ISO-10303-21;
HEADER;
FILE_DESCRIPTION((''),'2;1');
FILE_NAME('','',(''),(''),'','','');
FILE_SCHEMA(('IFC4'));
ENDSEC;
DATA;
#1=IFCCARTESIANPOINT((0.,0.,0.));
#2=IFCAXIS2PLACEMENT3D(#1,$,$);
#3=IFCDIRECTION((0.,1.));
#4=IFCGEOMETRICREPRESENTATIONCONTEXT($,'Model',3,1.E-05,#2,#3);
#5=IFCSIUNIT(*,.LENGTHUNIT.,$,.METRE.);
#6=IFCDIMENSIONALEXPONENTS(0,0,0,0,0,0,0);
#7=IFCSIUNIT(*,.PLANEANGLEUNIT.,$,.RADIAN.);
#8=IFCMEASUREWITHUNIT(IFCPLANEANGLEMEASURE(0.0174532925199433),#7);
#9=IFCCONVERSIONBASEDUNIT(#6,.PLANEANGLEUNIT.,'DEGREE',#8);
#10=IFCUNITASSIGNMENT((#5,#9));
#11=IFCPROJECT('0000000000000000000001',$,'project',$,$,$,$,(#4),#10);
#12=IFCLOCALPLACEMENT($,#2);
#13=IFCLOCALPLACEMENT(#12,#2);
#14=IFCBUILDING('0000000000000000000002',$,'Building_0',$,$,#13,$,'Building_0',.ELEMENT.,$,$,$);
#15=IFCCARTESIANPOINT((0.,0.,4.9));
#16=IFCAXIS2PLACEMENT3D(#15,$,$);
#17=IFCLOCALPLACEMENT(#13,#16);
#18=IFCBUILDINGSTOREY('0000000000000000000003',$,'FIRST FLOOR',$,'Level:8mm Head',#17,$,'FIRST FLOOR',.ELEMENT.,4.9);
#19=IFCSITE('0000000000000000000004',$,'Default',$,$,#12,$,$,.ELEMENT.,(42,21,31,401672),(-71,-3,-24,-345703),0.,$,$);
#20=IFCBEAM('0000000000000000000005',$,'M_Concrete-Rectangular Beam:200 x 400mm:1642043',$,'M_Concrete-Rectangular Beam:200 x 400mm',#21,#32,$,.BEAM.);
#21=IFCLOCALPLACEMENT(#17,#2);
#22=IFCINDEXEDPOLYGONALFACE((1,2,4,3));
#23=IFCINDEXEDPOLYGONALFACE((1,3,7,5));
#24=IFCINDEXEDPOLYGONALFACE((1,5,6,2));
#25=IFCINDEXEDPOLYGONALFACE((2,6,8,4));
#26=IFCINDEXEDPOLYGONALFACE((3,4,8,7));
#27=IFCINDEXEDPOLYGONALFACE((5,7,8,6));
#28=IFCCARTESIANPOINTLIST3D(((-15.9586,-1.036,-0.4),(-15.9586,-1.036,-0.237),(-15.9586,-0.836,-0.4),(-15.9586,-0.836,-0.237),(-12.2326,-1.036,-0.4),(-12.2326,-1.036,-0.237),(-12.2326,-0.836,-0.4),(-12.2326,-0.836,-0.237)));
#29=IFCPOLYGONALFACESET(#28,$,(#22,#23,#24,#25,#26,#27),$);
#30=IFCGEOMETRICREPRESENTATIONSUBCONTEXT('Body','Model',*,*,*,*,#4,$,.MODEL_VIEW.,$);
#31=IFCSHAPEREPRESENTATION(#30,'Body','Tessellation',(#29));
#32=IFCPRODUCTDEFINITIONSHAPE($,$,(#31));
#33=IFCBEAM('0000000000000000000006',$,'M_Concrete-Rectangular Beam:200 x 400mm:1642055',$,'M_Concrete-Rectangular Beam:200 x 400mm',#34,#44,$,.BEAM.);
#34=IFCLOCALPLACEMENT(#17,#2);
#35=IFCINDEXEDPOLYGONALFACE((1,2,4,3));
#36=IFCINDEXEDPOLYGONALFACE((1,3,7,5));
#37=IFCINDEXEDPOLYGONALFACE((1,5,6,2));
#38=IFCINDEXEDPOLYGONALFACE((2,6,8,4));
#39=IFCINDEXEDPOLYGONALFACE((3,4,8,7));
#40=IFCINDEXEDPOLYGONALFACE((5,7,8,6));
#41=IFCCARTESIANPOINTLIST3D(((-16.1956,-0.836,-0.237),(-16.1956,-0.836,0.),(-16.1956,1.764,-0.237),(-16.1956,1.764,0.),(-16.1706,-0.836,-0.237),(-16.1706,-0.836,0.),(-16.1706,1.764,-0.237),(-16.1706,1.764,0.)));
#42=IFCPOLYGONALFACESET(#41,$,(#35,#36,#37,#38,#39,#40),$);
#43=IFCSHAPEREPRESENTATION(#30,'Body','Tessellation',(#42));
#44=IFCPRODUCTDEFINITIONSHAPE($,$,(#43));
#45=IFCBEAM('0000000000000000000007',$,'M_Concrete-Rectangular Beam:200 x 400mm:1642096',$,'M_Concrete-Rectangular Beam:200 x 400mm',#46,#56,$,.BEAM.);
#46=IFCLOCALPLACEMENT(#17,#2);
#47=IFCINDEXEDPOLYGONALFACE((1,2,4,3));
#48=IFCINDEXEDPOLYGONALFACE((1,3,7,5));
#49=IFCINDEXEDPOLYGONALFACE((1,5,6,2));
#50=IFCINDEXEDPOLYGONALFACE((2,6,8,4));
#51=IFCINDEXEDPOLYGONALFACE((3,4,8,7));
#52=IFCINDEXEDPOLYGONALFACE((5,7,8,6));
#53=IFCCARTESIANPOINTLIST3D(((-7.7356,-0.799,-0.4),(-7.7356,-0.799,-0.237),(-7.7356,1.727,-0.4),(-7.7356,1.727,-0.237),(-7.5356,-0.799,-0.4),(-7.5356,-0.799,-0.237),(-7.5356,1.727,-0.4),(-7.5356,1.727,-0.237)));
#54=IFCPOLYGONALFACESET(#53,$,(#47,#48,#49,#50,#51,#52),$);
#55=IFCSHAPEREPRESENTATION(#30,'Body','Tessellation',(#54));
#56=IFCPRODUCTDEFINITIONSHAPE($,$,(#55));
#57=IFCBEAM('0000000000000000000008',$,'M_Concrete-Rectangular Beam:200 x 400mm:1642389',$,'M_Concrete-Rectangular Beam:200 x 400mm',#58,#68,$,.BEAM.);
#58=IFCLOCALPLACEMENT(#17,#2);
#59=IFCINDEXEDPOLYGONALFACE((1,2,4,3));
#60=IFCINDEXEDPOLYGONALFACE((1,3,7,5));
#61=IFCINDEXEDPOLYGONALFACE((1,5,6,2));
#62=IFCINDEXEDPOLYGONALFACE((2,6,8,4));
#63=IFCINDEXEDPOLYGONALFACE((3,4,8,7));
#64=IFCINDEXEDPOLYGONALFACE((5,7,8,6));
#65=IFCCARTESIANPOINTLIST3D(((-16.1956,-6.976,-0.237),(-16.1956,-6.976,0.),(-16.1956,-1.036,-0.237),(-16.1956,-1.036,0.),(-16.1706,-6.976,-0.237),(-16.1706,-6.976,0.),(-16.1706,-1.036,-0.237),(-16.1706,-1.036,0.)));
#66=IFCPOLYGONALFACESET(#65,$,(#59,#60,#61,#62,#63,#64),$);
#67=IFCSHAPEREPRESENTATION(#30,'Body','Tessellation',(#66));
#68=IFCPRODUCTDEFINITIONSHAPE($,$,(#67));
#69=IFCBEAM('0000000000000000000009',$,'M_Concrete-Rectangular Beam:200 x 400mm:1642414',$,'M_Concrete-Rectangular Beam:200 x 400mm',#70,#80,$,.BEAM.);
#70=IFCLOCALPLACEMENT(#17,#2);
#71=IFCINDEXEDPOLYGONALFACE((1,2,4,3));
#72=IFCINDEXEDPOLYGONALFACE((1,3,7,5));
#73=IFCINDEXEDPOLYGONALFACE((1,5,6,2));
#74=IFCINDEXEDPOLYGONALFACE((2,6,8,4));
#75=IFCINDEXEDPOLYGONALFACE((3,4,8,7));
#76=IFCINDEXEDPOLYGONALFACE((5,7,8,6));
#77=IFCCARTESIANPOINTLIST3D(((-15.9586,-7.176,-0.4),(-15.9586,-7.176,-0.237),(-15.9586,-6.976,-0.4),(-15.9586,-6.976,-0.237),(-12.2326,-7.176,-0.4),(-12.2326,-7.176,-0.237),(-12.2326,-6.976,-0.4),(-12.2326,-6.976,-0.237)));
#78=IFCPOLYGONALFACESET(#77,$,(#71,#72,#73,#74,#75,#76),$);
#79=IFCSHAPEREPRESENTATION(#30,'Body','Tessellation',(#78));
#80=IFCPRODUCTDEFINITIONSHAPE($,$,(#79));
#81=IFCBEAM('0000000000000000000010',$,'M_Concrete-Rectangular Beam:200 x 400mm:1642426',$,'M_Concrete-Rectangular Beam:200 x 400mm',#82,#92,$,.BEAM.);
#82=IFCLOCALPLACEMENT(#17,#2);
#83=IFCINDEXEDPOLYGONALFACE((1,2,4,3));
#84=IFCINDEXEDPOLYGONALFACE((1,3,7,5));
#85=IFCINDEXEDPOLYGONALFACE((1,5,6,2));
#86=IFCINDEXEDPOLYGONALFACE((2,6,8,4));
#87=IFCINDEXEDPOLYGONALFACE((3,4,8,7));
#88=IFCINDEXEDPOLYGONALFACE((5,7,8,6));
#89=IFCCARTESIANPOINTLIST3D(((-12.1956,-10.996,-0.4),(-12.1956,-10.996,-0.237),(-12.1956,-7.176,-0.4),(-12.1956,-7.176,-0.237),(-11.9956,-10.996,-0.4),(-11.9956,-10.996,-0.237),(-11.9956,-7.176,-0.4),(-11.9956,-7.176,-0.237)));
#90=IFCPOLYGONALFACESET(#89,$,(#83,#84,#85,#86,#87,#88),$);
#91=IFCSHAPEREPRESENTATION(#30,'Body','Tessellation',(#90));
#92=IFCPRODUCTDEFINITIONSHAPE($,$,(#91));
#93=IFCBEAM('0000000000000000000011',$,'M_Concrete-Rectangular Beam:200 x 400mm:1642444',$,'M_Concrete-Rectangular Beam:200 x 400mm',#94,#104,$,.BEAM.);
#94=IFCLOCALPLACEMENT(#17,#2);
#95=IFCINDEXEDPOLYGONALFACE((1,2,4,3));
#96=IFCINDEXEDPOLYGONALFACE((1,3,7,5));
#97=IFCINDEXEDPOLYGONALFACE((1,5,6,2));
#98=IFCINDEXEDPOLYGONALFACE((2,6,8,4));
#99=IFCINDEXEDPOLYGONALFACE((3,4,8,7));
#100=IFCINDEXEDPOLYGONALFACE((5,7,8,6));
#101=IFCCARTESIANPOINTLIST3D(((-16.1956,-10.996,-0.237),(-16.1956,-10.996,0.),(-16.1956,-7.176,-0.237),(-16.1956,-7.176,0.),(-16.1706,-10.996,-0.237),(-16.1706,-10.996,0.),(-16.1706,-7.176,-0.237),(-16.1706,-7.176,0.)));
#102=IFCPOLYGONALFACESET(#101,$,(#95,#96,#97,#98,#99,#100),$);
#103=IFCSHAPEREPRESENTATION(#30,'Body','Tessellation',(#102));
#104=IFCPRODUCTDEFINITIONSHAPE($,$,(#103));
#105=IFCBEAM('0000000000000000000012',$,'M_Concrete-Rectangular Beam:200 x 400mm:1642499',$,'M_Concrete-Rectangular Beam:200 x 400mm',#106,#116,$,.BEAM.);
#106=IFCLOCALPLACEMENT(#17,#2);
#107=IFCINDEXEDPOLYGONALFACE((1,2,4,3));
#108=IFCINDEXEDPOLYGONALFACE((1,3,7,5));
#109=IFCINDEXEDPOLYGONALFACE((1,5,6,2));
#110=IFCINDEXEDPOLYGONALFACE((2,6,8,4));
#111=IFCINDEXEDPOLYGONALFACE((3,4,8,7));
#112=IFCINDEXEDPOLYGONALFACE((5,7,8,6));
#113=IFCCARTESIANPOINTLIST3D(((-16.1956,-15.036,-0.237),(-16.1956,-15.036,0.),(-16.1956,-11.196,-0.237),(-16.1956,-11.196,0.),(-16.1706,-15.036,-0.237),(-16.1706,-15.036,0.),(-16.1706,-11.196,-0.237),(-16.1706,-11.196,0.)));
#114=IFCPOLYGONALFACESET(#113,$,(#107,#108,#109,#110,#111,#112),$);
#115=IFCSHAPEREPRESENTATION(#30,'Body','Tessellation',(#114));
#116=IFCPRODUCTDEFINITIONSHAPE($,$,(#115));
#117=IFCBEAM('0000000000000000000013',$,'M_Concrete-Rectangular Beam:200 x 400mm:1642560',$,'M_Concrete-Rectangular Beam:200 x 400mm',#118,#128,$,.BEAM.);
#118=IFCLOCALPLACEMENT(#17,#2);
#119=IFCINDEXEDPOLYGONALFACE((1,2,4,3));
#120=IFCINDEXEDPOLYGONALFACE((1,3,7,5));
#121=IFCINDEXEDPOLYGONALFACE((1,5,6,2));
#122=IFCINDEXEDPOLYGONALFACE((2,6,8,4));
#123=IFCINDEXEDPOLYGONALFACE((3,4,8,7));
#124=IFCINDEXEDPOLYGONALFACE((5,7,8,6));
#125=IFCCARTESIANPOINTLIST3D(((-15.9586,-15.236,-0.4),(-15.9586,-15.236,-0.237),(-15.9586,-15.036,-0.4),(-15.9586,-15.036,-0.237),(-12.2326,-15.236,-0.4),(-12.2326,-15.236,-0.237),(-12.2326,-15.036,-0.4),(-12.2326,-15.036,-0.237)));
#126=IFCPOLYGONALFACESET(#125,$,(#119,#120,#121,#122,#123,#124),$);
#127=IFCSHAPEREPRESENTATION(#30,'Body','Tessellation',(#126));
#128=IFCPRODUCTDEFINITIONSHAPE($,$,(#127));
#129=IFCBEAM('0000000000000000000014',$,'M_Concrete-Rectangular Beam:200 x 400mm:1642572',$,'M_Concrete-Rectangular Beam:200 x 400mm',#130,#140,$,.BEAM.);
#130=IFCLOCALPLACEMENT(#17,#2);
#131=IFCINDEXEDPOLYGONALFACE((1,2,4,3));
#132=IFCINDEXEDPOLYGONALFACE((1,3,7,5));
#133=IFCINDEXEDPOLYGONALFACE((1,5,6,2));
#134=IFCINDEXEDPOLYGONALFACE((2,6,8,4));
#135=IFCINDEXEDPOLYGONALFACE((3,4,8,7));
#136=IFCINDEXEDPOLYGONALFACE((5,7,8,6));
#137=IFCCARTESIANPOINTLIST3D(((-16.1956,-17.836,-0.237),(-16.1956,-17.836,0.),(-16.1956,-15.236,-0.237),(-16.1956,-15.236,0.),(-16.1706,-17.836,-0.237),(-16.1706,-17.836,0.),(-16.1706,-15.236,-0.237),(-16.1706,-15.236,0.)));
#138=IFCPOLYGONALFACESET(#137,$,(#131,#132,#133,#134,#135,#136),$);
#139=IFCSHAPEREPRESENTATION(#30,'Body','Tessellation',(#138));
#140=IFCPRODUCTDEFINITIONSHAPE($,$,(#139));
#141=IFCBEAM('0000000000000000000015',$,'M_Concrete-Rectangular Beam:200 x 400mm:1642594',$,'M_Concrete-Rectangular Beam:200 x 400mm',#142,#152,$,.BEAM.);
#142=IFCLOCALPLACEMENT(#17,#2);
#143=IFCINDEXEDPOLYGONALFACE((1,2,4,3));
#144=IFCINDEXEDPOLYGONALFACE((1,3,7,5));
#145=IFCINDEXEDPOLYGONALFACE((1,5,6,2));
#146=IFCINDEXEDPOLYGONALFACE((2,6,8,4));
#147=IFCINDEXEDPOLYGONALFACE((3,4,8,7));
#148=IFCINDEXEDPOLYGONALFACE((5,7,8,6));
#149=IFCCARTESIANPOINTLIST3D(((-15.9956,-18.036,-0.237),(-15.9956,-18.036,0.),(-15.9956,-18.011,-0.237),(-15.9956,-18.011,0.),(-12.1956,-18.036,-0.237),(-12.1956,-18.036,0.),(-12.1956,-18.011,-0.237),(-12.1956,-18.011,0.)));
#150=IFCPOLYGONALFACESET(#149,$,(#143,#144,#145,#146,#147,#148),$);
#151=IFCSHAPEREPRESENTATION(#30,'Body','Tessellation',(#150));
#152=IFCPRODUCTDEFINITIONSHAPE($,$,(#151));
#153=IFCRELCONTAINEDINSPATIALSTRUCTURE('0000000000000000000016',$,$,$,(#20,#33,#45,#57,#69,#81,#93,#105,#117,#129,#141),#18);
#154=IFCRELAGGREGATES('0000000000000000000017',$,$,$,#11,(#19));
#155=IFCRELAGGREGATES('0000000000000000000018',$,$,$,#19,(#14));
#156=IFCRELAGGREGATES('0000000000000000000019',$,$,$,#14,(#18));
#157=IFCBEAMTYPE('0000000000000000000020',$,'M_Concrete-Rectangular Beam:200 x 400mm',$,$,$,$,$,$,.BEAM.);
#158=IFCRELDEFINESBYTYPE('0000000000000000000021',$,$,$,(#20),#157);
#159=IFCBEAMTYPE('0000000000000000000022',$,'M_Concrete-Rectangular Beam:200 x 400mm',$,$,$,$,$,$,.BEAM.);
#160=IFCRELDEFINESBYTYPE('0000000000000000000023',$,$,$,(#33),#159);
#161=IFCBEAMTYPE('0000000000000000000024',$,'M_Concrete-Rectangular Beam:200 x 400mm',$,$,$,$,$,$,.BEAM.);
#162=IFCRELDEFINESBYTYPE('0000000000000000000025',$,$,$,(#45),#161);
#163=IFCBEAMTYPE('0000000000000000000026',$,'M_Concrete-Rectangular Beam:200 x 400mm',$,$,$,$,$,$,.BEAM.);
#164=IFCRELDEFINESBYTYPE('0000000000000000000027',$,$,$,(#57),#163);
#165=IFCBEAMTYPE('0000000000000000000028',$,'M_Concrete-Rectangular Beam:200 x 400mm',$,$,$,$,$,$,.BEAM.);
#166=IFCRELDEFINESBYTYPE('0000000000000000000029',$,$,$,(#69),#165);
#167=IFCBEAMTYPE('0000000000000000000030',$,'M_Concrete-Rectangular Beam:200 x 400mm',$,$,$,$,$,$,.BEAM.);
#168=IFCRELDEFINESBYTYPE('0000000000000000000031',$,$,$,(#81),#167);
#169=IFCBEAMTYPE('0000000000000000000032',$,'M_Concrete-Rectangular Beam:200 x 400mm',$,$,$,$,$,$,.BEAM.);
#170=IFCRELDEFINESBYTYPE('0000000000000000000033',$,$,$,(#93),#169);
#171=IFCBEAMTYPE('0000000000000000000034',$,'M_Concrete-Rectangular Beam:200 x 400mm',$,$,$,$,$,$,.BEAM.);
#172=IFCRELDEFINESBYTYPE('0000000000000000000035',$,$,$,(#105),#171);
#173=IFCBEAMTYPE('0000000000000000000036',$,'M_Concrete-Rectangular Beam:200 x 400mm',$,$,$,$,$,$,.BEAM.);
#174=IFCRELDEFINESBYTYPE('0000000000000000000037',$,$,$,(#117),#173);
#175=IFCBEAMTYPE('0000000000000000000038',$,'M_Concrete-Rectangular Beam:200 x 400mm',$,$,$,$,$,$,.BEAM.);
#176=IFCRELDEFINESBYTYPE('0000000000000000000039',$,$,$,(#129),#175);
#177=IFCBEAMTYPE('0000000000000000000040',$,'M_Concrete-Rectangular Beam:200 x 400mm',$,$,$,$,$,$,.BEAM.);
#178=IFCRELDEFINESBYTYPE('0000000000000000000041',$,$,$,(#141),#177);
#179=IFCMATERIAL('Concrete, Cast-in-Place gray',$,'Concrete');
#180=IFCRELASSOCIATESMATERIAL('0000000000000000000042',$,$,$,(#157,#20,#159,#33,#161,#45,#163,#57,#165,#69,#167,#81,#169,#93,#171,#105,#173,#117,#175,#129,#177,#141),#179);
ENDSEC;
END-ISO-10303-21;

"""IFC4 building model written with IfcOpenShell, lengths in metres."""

from ifc_helpers import new_model, entity, si_unit, converted_unit, direction, frame, origin, place, context, subcontext, project, spatial, indexed_curve, outline, extrude, source, transform, mapped, material, type_object, type_shapes, element, save


model = new_model("IFC4")

# Units and contexts
model_context = context("Model", 3, precision=1e-05, world=origin(), true_north=direction((0.0, 1.0)))
body_context = subcontext(model_context, "Body", "Model", "MODEL_VIEW")
ifc_project = project(units=[si_unit("LENGTHUNIT", "METRE"), converted_unit("PLANEANGLEUNIT", "DEGREE", entity("IfcPlaneAngleMeasure", 0.0174532925199433), si_unit("PLANEANGLEUNIT", "RADIAN"), dimensions=[0, 0, 0, 0, 0, 0, 0])], contexts=[model_context])

# Site, building, storey
site_placement = place(None, origin())
site = spatial("IfcSite", under=ifc_project, at=site_placement, Name="Default", CompositionType="ELEMENT", RefLatitude=(42, 21, 31, 401672), RefLongitude=(-71, -3, -24, -345703), RefElevation=0.0)
building_placement = place(site_placement, origin())
building = spatial("IfcBuilding", under=site, at=building_placement, Name="Building_0", LongName="Building_0", CompositionType="ELEMENT")
storey_placement = place(building_placement, frame((0.0, 0.0, 4.9)))
storey = spatial("IfcBuildingStorey", under=building, at=storey_placement, Name="FIRST FLOOR", ObjectType="Level:8mm Head", LongName="FIRST FLOOR", CompositionType="ELEMENT", Elevation=4.9)

# Beams
ifc_material = material(Name="Concrete, Cast-in-Place gray", Category="Concrete")
beam_type_1 = type_object("IfcBeamType", Name="M_Concrete-Rectangular Beam:200 x 400mm", PredefinedType="BEAM", material=ifc_material)
shared_shape_1 = source(origin(), body_context, "Body", "SweptSolid", [
    extrude(outline(indexed_curve([(-0.0815, -0.1), (0.0815, -0.1), (0.0815, 0.1), (-0.0815, 0.1), (-0.0815, -0.1)], self_intersect=False)), frame((-12.2326, -0.936, 4.5815), z_axis=(-1.0, 0.0, 0.0), x_axis=(0.0, 0.0, -1.0)), (0.0, 0.0, 1.0), 3.726),
])
type_shapes(beam_type_1, [shared_shape_1])
beam_1_placement = place(storey_placement, frame((0.0, 0.0, -4.9)))
element("IfcBeam", 1, at=beam_1_placement, inside=storey, type_object=beam_type_1, material=ifc_material, Name="M_Concrete-Rectangular Beam:200 x 400mm:1642043", ObjectType="M_Concrete-Rectangular Beam:200 x 400mm", PredefinedType="BEAM", context=body_context, shape_type="MappedRepresentation", body=[
    mapped(shared_shape_1, transform((0.0, 0.0, 0.0), scale=1.0)),
])
beam_type_2 = type_object("IfcBeamType", Name="M_Concrete-Rectangular Beam:200 x 400mm", PredefinedType="BEAM", material=ifc_material)
shared_shape_2 = source(origin(), body_context, "Body", "SweptSolid", [
    extrude(outline(indexed_curve([(-0.0125, -0.1185), (0.0125, -0.1185), (0.0125, 0.1185), (-0.0125, 0.1185), (-0.0125, -0.1185)], self_intersect=False)), frame((-16.1831, -0.836, 4.7815), z_axis=(0.0, 1.0, 0.0), x_axis=(-1.0, 0.0, 0.0)), (0.0, 0.0, 1.0), 2.6),
])
type_shapes(beam_type_2, [shared_shape_2])
beam_2_placement = place(storey_placement, frame((0.0, 0.0, -4.9)))
element("IfcBeam", 2, at=beam_2_placement, inside=storey, type_object=beam_type_2, material=ifc_material, Name="M_Concrete-Rectangular Beam:200 x 400mm:1642055", ObjectType="M_Concrete-Rectangular Beam:200 x 400mm", PredefinedType="BEAM", context=body_context, shape_type="MappedRepresentation", body=[
    mapped(shared_shape_2, transform((0.0, 0.0, 0.0), scale=1.0)),
])
beam_type_3 = type_object("IfcBeamType", Name="M_Concrete-Rectangular Beam:200 x 400mm", PredefinedType="BEAM", material=ifc_material)
shared_shape_3 = source(origin(), body_context, "Body", "SweptSolid", [
    extrude(outline(indexed_curve([(-0.1, -0.0815), (0.1, -0.0815), (0.1, 0.0815), (-0.1, 0.0815), (-0.1, -0.0815)], self_intersect=False)), frame((-7.6356, 1.727, 4.5815), z_axis=(0.0, -1.0, 0.0), x_axis=(-1.0, 0.0, 0.0)), (0.0, 0.0, 1.0), 2.526),
])
type_shapes(beam_type_3, [shared_shape_3])
beam_3_placement = place(storey_placement, frame((0.0, 0.0, -4.9)))
element("IfcBeam", 3, at=beam_3_placement, inside=storey, type_object=beam_type_3, material=ifc_material, Name="M_Concrete-Rectangular Beam:200 x 400mm:1642096", ObjectType="M_Concrete-Rectangular Beam:200 x 400mm", PredefinedType="BEAM", context=body_context, shape_type="MappedRepresentation", body=[
    mapped(shared_shape_3, transform((0.0, 0.0, 0.0), scale=1.0)),
])
beam_type_4 = type_object("IfcBeamType", Name="M_Concrete-Rectangular Beam:200 x 400mm", PredefinedType="BEAM", material=ifc_material)
shared_shape_4 = source(origin(), body_context, "Body", "SweptSolid", [
    extrude(outline(indexed_curve([(-0.0125, -0.1185), (0.0125, -0.1185), (0.0125, 0.1185), (-0.0125, 0.1185), (-0.0125, -0.1185)], self_intersect=False)), frame((-16.1831, -1.036, 4.7815), z_axis=(0.0, -1.0, 0.0), x_axis=(-1.0, 0.0, 0.0)), (0.0, 0.0, 1.0), 5.94),
])
type_shapes(beam_type_4, [shared_shape_4])
beam_4_placement = place(storey_placement, frame((0.0, 0.0, -4.9)))
element("IfcBeam", 4, at=beam_4_placement, inside=storey, type_object=beam_type_4, material=ifc_material, Name="M_Concrete-Rectangular Beam:200 x 400mm:1642389", ObjectType="M_Concrete-Rectangular Beam:200 x 400mm", PredefinedType="BEAM", context=body_context, shape_type="MappedRepresentation", body=[
    mapped(shared_shape_4, transform((0.0, 0.0, 0.0), scale=1.0)),
])
beam_type_5 = type_object("IfcBeamType", Name="M_Concrete-Rectangular Beam:200 x 400mm", PredefinedType="BEAM", material=ifc_material)
shared_shape_5 = source(origin(), body_context, "Body", "SweptSolid", [
    extrude(outline(indexed_curve([(-0.0815, -0.1), (0.0815, -0.1), (0.0815, 0.1), (-0.0815, 0.1), (-0.0815, -0.1)], self_intersect=False)), frame((-15.9586, -7.076, 4.5815), z_axis=(1.0, 0.0, 0.0), x_axis=(0.0, 0.0, -1.0)), (0.0, 0.0, 1.0), 3.726),
])
type_shapes(beam_type_5, [shared_shape_5])
beam_5_placement = place(storey_placement, frame((0.0, 0.0, -4.9)))
element("IfcBeam", 5, at=beam_5_placement, inside=storey, type_object=beam_type_5, material=ifc_material, Name="M_Concrete-Rectangular Beam:200 x 400mm:1642414", ObjectType="M_Concrete-Rectangular Beam:200 x 400mm", PredefinedType="BEAM", context=body_context, shape_type="MappedRepresentation", body=[
    mapped(shared_shape_5, transform((0.0, 0.0, 0.0), scale=1.0)),
])
beam_type_6 = type_object("IfcBeamType", Name="M_Concrete-Rectangular Beam:200 x 400mm", PredefinedType="BEAM", material=ifc_material)
shared_shape_6 = source(origin(), body_context, "Body", "SweptSolid", [
    extrude(outline(indexed_curve([(-0.1, -0.0815), (0.1, -0.0815), (0.1, 0.0815), (-0.1, 0.0815), (-0.1, -0.0815)], self_intersect=False)), frame((-12.0956, -7.176, 4.5815), z_axis=(0.0, -1.0, 0.0), x_axis=(-1.0, 0.0, 0.0)), (0.0, 0.0, 1.0), 3.82),
])
type_shapes(beam_type_6, [shared_shape_6])
beam_6_placement = place(storey_placement, frame((0.0, 0.0, -4.9)))
element("IfcBeam", 6, at=beam_6_placement, inside=storey, type_object=beam_type_6, material=ifc_material, Name="M_Concrete-Rectangular Beam:200 x 400mm:1642426", ObjectType="M_Concrete-Rectangular Beam:200 x 400mm", PredefinedType="BEAM", context=body_context, shape_type="MappedRepresentation", body=[
    mapped(shared_shape_6, transform((0.0, 0.0, 0.0), scale=1.0)),
])
beam_type_7 = type_object("IfcBeamType", Name="M_Concrete-Rectangular Beam:200 x 400mm", PredefinedType="BEAM", material=ifc_material)
shared_shape_7 = source(origin(), body_context, "Body", "SweptSolid", [
    extrude(outline(indexed_curve([(-0.0125, -0.1185), (0.0125, -0.1185), (0.0125, 0.1185), (-0.0125, 0.1185), (-0.0125, -0.1185)], self_intersect=False)), frame((-16.1831, -7.176, 4.7815), z_axis=(0.0, -1.0, 0.0), x_axis=(-1.0, 0.0, 0.0)), (0.0, 0.0, 1.0), 3.82),
])
type_shapes(beam_type_7, [shared_shape_7])
beam_7_placement = place(storey_placement, frame((0.0, 0.0, -4.9)))
element("IfcBeam", 7, at=beam_7_placement, inside=storey, type_object=beam_type_7, material=ifc_material, Name="M_Concrete-Rectangular Beam:200 x 400mm:1642444", ObjectType="M_Concrete-Rectangular Beam:200 x 400mm", PredefinedType="BEAM", context=body_context, shape_type="MappedRepresentation", body=[
    mapped(shared_shape_7, transform((0.0, 0.0, 0.0), scale=1.0)),
])
beam_type_8 = type_object("IfcBeamType", Name="M_Concrete-Rectangular Beam:200 x 400mm", PredefinedType="BEAM", material=ifc_material)
shared_shape_8 = source(origin(), body_context, "Body", "SweptSolid", [
    extrude(outline(indexed_curve([(-0.0125, -0.1185), (0.0125, -0.1185), (0.0125, 0.1185), (-0.0125, 0.1185), (-0.0125, -0.1185)], self_intersect=False)), frame((-16.1831, -11.196, 4.7815), z_axis=(0.0, -1.0, 0.0), x_axis=(-1.0, 0.0, 0.0)), (0.0, 0.0, 1.0), 3.84),
])
type_shapes(beam_type_8, [shared_shape_8])
beam_8_placement = place(storey_placement, frame((0.0, 0.0, -4.9)))
element("IfcBeam", 8, at=beam_8_placement, inside=storey, type_object=beam_type_8, material=ifc_material, Name="M_Concrete-Rectangular Beam:200 x 400mm:1642499", ObjectType="M_Concrete-Rectangular Beam:200 x 400mm", PredefinedType="BEAM", context=body_context, shape_type="MappedRepresentation", body=[
    mapped(shared_shape_8, transform((0.0, 0.0, 0.0), scale=1.0)),
])
beam_type_9 = type_object("IfcBeamType", Name="M_Concrete-Rectangular Beam:200 x 400mm", PredefinedType="BEAM", material=ifc_material)
shared_shape_9 = source(origin(), body_context, "Body", "SweptSolid", [
    extrude(outline(indexed_curve([(-0.0815, -0.1), (0.0815, -0.1), (0.0815, 0.1), (-0.0815, 0.1), (-0.0815, -0.1)], self_intersect=False)), frame((-12.2326, -15.136, 4.5815), z_axis=(-1.0, 0.0, 0.0), x_axis=(0.0, 0.0, -1.0)), (0.0, 0.0, 1.0), 3.726),
])
type_shapes(beam_type_9, [shared_shape_9])
beam_9_placement = place(storey_placement, frame((0.0, 0.0, -4.9)))
element("IfcBeam", 9, at=beam_9_placement, inside=storey, type_object=beam_type_9, material=ifc_material, Name="M_Concrete-Rectangular Beam:200 x 400mm:1642560", ObjectType="M_Concrete-Rectangular Beam:200 x 400mm", PredefinedType="BEAM", context=body_context, shape_type="MappedRepresentation", body=[
    mapped(shared_shape_9, transform((0.0, 0.0, 0.0), scale=1.0)),
])
beam_type_10 = type_object("IfcBeamType", Name="M_Concrete-Rectangular Beam:200 x 400mm", PredefinedType="BEAM", material=ifc_material)
shared_shape_10 = source(origin(), body_context, "Body", "SweptSolid", [
    extrude(outline(indexed_curve([(-0.0125, -0.1185), (0.0125, -0.1185), (0.0125, 0.1185), (-0.0125, 0.1185), (-0.0125, -0.1185)], self_intersect=False)), frame((-16.1831, -15.236, 4.7815), z_axis=(0.0, -1.0, 0.0), x_axis=(-1.0, 0.0, 0.0)), (0.0, 0.0, 1.0), 2.6),
])
type_shapes(beam_type_10, [shared_shape_10])
beam_10_placement = place(storey_placement, frame((0.0, 0.0, -4.9)))
element("IfcBeam", 10, at=beam_10_placement, inside=storey, type_object=beam_type_10, material=ifc_material, Name="M_Concrete-Rectangular Beam:200 x 400mm:1642572", ObjectType="M_Concrete-Rectangular Beam:200 x 400mm", PredefinedType="BEAM", context=body_context, shape_type="MappedRepresentation", body=[
    mapped(shared_shape_10, transform((0.0, 0.0, 0.0), scale=1.0)),
])
beam_type_11 = type_object("IfcBeamType", Name="M_Concrete-Rectangular Beam:200 x 400mm", PredefinedType="BEAM", material=ifc_material)
shared_shape_11 = source(origin(), body_context, "Body", "SweptSolid", [
    extrude(outline(indexed_curve([(-0.1185, -0.0125), (0.1185, -0.0125), (0.1185, 0.0125), (-0.1185, 0.0125), (-0.1185, -0.0125)], self_intersect=False)), frame((-15.9956, -18.0235, 4.7815), z_axis=(1.0, 0.0, 0.0), x_axis=(0.0, 0.0, -1.0)), (0.0, 0.0, 1.0), 3.8),
])
type_shapes(beam_type_11, [shared_shape_11])
beam_11_placement = place(storey_placement, frame((0.0, 0.0, -4.9)))
element("IfcBeam", 11, at=beam_11_placement, inside=storey, type_object=beam_type_11, material=ifc_material, Name="M_Concrete-Rectangular Beam:200 x 400mm:1642594", ObjectType="M_Concrete-Rectangular Beam:200 x 400mm", PredefinedType="BEAM", context=body_context, shape_type="MappedRepresentation", body=[
    mapped(shared_shape_11, transform((0.0, 0.0, 0.0), scale=1.0)),
])

save(model, "model.ifc")
